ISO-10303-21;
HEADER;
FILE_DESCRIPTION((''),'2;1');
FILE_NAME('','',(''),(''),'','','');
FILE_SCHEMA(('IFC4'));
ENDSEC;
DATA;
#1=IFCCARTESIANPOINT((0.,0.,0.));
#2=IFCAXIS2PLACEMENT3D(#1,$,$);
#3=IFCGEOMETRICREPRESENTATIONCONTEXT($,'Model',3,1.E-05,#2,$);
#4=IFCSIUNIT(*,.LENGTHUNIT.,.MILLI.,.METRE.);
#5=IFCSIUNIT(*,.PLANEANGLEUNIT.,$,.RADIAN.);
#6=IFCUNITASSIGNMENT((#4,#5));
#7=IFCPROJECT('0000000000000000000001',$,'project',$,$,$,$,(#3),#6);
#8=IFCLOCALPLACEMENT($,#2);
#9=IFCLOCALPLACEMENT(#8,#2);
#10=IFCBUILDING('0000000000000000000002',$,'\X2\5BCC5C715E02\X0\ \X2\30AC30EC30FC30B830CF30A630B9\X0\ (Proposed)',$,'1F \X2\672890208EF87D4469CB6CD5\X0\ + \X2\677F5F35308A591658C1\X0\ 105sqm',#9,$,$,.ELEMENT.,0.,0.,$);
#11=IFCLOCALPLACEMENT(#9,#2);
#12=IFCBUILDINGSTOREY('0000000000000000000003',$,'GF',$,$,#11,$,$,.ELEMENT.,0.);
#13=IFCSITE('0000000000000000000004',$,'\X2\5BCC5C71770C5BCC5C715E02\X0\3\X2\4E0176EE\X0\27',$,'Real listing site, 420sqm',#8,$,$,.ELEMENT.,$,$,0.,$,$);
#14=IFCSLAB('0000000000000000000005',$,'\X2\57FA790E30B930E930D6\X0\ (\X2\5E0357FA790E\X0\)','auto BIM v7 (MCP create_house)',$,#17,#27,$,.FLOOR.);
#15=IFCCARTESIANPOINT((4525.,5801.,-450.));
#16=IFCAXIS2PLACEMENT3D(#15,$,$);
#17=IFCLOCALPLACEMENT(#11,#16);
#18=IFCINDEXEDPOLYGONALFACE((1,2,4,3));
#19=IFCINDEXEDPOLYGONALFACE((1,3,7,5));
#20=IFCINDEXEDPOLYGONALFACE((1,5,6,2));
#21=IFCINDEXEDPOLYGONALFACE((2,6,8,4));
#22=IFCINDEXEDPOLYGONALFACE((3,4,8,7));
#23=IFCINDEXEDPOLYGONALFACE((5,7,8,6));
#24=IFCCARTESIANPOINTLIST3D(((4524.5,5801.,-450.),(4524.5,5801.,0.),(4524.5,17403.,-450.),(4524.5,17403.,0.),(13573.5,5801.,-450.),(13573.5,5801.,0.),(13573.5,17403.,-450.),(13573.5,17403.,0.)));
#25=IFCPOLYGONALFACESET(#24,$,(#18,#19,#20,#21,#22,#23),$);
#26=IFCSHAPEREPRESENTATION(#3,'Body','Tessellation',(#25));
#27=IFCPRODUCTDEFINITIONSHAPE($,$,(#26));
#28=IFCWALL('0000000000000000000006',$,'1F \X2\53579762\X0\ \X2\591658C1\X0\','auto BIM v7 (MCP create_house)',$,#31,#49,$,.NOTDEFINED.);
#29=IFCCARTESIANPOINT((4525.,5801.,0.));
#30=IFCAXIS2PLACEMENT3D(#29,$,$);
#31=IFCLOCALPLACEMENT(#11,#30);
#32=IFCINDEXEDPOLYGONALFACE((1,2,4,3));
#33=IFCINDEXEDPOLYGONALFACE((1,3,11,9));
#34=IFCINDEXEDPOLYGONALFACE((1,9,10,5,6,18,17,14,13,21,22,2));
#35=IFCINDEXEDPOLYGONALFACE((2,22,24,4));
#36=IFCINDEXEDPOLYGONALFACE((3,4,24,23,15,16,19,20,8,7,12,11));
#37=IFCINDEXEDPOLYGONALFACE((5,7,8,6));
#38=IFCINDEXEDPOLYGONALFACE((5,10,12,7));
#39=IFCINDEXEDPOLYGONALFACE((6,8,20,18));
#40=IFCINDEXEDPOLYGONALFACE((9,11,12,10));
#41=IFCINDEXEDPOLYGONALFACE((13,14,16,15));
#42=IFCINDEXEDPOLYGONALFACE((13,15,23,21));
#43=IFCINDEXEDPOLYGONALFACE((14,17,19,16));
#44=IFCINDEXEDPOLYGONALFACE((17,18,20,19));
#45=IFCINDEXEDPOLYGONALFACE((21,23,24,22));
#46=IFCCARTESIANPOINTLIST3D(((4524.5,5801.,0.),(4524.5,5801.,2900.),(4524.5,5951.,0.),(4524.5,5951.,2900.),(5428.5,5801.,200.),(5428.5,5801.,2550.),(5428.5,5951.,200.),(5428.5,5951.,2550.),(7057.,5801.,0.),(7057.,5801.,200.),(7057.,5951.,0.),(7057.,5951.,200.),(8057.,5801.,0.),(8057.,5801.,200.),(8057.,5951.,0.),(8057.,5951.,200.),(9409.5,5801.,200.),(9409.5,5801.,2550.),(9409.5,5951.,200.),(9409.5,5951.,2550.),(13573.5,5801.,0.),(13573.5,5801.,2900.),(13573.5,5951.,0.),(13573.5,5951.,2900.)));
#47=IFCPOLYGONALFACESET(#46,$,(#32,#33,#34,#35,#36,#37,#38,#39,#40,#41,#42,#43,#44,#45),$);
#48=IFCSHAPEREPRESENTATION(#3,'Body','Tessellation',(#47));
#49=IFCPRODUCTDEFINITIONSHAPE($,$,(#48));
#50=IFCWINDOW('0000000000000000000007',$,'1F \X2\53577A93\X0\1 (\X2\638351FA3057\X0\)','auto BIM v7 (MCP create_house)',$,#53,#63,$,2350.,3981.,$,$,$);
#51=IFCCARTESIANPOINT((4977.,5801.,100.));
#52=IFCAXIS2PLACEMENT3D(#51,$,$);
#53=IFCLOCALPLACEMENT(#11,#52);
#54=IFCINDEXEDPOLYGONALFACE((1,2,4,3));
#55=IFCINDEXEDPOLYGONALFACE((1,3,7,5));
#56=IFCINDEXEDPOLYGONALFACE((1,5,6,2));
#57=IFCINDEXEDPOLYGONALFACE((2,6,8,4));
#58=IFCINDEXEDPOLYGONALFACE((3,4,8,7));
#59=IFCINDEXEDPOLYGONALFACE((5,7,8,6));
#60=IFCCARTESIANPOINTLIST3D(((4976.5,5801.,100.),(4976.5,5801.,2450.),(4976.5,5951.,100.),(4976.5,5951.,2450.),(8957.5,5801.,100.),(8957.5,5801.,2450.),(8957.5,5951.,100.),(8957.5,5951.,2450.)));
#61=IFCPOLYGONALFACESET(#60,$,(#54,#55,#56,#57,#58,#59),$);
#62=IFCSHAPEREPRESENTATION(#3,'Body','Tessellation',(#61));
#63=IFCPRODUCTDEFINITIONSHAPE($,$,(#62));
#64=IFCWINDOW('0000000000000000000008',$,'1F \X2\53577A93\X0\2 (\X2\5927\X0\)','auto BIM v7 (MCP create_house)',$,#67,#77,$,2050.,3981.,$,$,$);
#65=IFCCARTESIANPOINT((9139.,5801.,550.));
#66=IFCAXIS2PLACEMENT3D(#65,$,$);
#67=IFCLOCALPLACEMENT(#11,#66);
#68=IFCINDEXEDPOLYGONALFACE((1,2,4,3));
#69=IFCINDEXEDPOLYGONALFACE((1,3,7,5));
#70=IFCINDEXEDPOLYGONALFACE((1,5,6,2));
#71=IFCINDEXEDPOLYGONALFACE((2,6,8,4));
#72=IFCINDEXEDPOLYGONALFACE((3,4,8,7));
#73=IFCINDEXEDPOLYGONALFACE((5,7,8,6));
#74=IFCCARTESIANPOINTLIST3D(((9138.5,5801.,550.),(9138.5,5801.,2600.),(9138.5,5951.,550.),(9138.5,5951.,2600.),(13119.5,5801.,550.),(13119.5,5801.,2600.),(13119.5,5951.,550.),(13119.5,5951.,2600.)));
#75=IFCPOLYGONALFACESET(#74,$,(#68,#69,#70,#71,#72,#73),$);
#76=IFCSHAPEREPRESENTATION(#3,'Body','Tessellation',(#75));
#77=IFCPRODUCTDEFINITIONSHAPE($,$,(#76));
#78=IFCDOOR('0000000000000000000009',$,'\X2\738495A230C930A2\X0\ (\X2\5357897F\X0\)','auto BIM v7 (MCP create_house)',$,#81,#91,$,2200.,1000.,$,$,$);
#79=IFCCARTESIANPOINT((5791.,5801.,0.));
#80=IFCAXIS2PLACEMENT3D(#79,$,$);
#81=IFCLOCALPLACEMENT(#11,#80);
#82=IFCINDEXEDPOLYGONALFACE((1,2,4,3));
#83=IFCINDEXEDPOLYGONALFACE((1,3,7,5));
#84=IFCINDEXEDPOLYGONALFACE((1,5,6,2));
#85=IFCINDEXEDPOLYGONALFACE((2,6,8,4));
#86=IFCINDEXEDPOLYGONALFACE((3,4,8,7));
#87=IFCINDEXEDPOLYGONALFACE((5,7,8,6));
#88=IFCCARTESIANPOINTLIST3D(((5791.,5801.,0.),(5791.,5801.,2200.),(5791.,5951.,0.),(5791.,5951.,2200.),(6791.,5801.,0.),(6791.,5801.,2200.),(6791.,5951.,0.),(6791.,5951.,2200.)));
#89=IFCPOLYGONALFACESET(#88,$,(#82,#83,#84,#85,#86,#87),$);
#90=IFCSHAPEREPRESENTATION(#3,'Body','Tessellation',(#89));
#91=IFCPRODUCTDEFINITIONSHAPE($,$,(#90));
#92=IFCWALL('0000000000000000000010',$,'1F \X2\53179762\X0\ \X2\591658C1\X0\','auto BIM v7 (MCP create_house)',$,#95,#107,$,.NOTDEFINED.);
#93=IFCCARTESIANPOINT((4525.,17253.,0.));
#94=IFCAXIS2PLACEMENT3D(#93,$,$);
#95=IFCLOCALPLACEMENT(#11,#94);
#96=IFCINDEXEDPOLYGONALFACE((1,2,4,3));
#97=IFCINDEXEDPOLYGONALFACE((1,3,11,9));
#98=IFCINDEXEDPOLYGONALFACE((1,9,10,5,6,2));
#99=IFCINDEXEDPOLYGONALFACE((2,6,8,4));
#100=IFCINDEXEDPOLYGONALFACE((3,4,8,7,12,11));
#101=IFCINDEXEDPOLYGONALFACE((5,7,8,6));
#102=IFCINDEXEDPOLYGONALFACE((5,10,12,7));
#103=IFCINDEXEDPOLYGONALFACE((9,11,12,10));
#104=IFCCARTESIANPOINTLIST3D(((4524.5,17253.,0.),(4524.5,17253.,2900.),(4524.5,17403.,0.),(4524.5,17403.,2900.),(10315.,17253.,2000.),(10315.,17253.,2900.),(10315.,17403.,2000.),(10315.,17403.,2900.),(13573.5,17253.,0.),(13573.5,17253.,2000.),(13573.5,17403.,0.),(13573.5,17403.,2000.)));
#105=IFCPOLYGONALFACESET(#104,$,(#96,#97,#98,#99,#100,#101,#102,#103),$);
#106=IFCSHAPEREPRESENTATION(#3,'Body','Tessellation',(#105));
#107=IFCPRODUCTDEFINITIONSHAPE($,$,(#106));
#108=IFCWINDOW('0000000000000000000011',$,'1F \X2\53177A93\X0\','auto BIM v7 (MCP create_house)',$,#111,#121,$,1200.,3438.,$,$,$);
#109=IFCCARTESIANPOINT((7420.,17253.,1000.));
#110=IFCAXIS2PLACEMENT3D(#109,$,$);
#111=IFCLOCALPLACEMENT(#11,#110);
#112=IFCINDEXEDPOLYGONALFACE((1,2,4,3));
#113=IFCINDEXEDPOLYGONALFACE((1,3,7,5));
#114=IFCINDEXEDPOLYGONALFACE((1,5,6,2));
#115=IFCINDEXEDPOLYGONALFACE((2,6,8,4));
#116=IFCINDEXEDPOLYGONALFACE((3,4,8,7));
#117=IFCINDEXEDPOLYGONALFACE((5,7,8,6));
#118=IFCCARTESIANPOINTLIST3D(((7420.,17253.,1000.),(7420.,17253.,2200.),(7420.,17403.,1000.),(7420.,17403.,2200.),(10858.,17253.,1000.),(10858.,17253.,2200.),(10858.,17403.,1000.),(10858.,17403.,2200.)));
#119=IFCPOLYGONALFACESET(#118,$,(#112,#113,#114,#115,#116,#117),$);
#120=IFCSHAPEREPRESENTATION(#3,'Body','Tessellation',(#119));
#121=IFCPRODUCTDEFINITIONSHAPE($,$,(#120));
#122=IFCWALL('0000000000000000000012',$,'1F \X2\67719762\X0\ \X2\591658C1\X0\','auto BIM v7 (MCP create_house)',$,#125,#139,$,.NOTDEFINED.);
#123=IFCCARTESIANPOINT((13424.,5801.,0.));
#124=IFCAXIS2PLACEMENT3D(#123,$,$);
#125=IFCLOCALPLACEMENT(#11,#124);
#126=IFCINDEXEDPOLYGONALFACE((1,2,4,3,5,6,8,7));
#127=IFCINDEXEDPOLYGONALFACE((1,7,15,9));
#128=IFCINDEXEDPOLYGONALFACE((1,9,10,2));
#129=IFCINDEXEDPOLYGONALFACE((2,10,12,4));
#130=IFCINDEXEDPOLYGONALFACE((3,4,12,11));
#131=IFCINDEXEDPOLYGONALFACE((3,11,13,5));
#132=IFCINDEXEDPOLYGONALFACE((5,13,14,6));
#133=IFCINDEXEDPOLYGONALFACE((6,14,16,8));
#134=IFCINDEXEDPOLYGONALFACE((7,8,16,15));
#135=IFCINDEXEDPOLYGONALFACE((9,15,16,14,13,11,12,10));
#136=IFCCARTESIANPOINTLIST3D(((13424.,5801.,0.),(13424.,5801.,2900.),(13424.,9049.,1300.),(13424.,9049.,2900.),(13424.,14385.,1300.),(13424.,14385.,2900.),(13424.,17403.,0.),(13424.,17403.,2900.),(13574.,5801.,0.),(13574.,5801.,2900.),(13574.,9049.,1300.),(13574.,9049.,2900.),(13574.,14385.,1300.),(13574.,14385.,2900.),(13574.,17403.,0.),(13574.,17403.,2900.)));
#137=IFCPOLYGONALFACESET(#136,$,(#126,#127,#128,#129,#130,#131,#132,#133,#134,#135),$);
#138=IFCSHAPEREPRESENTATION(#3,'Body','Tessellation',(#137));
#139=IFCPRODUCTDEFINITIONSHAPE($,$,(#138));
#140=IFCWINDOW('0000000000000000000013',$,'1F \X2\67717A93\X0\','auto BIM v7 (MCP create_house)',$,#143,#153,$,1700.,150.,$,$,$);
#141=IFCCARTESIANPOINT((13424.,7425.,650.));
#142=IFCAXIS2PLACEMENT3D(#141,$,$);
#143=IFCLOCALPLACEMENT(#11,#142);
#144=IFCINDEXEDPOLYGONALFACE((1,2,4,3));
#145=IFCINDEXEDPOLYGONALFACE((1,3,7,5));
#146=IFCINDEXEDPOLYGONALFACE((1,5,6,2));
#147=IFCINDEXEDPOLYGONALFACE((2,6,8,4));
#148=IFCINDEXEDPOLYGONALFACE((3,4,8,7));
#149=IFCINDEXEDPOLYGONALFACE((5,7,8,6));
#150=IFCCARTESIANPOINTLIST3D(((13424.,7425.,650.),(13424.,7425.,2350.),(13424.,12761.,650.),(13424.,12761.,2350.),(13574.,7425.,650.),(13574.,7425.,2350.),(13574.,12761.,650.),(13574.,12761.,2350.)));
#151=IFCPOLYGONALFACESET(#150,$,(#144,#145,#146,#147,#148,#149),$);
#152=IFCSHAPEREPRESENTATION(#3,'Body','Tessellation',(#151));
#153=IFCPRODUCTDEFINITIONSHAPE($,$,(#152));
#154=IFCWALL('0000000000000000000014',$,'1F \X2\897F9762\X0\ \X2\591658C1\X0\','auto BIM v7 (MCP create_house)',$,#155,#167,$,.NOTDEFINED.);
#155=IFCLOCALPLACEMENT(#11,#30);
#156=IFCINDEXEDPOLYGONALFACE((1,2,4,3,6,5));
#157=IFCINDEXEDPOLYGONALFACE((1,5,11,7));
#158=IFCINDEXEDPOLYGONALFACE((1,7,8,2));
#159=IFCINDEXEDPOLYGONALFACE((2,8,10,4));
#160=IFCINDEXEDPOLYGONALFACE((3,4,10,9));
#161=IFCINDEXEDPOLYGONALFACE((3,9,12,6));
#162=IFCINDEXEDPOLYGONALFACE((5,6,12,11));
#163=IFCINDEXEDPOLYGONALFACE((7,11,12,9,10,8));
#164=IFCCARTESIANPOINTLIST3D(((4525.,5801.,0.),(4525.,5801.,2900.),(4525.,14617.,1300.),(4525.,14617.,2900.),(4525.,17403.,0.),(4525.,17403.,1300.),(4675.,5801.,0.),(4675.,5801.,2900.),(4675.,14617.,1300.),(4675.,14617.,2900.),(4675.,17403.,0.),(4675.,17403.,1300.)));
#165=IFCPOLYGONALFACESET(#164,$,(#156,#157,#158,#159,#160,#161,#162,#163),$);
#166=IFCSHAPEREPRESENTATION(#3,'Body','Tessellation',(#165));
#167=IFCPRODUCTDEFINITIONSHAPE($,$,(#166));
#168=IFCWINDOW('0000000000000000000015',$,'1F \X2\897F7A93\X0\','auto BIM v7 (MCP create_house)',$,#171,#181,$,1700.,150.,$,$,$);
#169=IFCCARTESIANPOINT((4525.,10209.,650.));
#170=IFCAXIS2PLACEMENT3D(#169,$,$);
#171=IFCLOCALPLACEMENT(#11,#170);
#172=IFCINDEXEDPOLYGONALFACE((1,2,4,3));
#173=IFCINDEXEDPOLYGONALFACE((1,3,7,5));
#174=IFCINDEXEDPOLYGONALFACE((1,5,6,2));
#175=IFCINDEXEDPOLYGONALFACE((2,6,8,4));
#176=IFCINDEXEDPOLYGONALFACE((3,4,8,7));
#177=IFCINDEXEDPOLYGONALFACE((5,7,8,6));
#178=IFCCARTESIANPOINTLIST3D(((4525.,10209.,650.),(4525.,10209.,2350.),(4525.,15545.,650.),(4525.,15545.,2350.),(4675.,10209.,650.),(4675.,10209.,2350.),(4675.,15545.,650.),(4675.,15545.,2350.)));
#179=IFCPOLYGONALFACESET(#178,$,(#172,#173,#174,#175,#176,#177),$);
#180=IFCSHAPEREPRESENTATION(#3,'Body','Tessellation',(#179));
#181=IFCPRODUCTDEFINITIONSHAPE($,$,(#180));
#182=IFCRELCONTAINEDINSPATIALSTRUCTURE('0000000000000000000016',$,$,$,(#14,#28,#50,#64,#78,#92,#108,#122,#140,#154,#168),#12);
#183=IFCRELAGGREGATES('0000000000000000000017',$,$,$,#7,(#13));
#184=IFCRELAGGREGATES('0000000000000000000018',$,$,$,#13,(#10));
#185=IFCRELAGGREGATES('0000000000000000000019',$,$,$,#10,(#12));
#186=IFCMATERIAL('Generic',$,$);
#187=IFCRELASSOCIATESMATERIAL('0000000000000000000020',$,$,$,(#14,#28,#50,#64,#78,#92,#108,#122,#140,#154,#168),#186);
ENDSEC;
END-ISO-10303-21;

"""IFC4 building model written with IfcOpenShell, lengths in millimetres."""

from ifc_helpers import new_model, si_unit, frame, frame_2d, origin, place, context, project, spatial, rectangle, extrude, material, element, fill, save


model = new_model("IFC4")

# Units and contexts
model_context = context("Model", 3, precision=1e-05, world=origin())
ifc_project = project(units=[si_unit("LENGTHUNIT", "METRE", prefix="MILLI"), si_unit("PLANEANGLEUNIT", "RADIAN")], contexts=[model_context])

# Site, building, storey
site_placement = place(None, origin())
site = spatial("IfcSite", under=ifc_project, at=site_placement, Name="富山県富山市3丁目27", ObjectType="Real listing site, 420sqm", CompositionType="ELEMENT", RefElevation=0.0)
building_placement = place(site_placement, origin())
building = spatial("IfcBuilding", under=site, at=building_placement, Name="富山市 ガレージハウス (Proposed)", ObjectType="1F 木造軸組構法 + 板張り外壁 105sqm", CompositionType="ELEMENT", ElevationOfRefHeight=0.0, ElevationOfTerrain=0.0)
storey_placement = place(building_placement, origin())
storey = spatial("IfcBuildingStorey", under=building, at=storey_placement, Name="GF", CompositionType="ELEMENT", Elevation=0.0)

# Slab
ifc_material = material(Name="Generic")
slab_1_placement = place(storey_placement, frame((4525.0, 5801.0, -450.0)))
element("IfcSlab", 1, at=slab_1_placement, inside=storey, material=ifc_material, Name="基礎スラブ (布基礎)", Description="auto BIM v7 (MCP create_house)", PredefinedType="FLOOR", context=model_context, shape_type="SweptSolid", body=[
    extrude(rectangle(XDim=9049.0, YDim=11602.0, at=frame_2d((4524.0, 5801.0))), frame((4525.0, 5801.0, -450.0)), (0.0, 0.0, 1.0), 450.0),
])

# Wall, openings, windows, door
wall_1_placement = place(storey_placement, frame((4525.0, 5801.0, 0.0)))
wall_1 = element("IfcWall", 2, at=wall_1_placement, inside=storey, material=ifc_material, Name="1F 南面 外壁", Description="auto BIM v7 (MCP create_house)", PredefinedType="NOTDEFINED", context=model_context, shape_type="SweptSolid", body=[
    extrude(rectangle(XDim=9049.0, YDim=150.0, at=frame_2d((4524.0, 75.0))), frame((4525.0, 5801.0, 0.0)), (0.0, 0.0, 1.0), 2900.0),
])
opening_1_placement = place(storey_placement, frame((4977.0, 5801.0, 100.0)))
opening_1 = element("IfcOpeningElement", 3, at=opening_1_placement, cuts=wall_1, PredefinedType="NOTDEFINED", context=model_context, shape_type="SweptSolid", body=[
    extrude(rectangle(XDim=3981.0, YDim=150.0, at=frame_2d((1990.0, 75.0))), frame((4977.0, 5801.0, 100.0)), (0.0, 0.0, 1.0), 2350.0),
])
opening_2_placement = place(storey_placement, frame((9139.0, 5801.0, 550.0)))
opening_2 = element("IfcOpeningElement", 4, at=opening_2_placement, cuts=wall_1, PredefinedType="NOTDEFINED", context=model_context, shape_type="SweptSolid", body=[
    extrude(rectangle(XDim=3981.0, YDim=150.0, at=frame_2d((1990.0, 75.0))), frame((9139.0, 5801.0, 550.0)), (0.0, 0.0, 1.0), 2050.0),
])
opening_3_placement = place(storey_placement, frame((5791.0, 5801.0, 0.0)))
opening_3 = element("IfcOpeningElement", 5, at=opening_3_placement, cuts=wall_1, PredefinedType="NOTDEFINED", context=model_context, shape_type="SweptSolid", body=[
    extrude(rectangle(XDim=1000.0, YDim=150.0, at=frame_2d((500.0, 75.0))), frame((5791.0, 5801.0, 0.0)), (0.0, 0.0, 1.0), 2200.0),
])
window_1_placement = place(storey_placement, frame((4977.0, 5801.0, 100.0)))
window_1 = element("IfcWindow", 6, at=window_1_placement, inside=storey, material=ifc_material, Name="1F 南窓1 (掃出し)", Description="auto BIM v7 (MCP create_house)", OverallHeight=2350.0, OverallWidth=3981.0, context=model_context, shape_type="SweptSolid", body=[
    extrude(rectangle(XDim=3981.0, YDim=150.0, at=frame_2d((1990.0, 75.0))), frame((4977.0, 5801.0, 100.0)), (0.0, 0.0, 1.0), 2350.0),
])
fill(opening_1, window_1)
window_2_placement = place(storey_placement, frame((9139.0, 5801.0, 550.0)))
window_2 = element("IfcWindow", 7, at=window_2_placement, inside=storey, material=ifc_material, Name="1F 南窓2 (大)", Description="auto BIM v7 (MCP create_house)", OverallHeight=2050.0, OverallWidth=3981.0, context=model_context, shape_type="SweptSolid", body=[
    extrude(rectangle(XDim=3981.0, YDim=150.0, at=frame_2d((1990.0, 75.0))), frame((9139.0, 5801.0, 550.0)), (0.0, 0.0, 1.0), 2050.0),
])
fill(opening_2, window_2)
door_placement = place(storey_placement, frame((5791.0, 5801.0, 0.0)))
door = element("IfcDoor", 8, at=door_placement, inside=storey, material=ifc_material, Name="玄関ドア (南西)", Description="auto BIM v7 (MCP create_house)", OverallHeight=2200.0, OverallWidth=1000.0, context=model_context, shape_type="SweptSolid", body=[
    extrude(rectangle(XDim=1000.0, YDim=150.0, at=frame_2d((500.0, 75.0))), frame((5791.0, 5801.0, 0.0)), (0.0, 0.0, 1.0), 2200.0),
])
fill(opening_3, door)

# Walls, openings, windows
wall_2_placement = place(storey_placement, frame((4525.0, 17253.0, 0.0)))
wall_2 = element("IfcWall", 9, at=wall_2_placement, inside=storey, material=ifc_material, Name="1F 北面 外壁", Description="auto BIM v7 (MCP create_house)", PredefinedType="NOTDEFINED", context=model_context, shape_type="SweptSolid", body=[
    extrude(rectangle(XDim=9049.0, YDim=150.0, at=frame_2d((4524.0, 75.0))), frame((4525.0, 17253.0, 0.0)), (0.0, 0.0, 1.0), 2900.0),
])
opening_4_placement = place(storey_placement, frame((7420.0, 17253.0, 1000.0)))
opening_4 = element("IfcOpeningElement", 10, at=opening_4_placement, cuts=wall_2, PredefinedType="NOTDEFINED", context=model_context, shape_type="SweptSolid", body=[
    extrude(rectangle(XDim=3438.0, YDim=150.0, at=frame_2d((1719.0, 75.0))), frame((7420.0, 17253.0, 1000.0)), (0.0, 0.0, 1.0), 1200.0),
])
window_3_placement = place(storey_placement, frame((7420.0, 17253.0, 1000.0)))
window_3 = element("IfcWindow", 11, at=window_3_placement, inside=storey, material=ifc_material, Name="1F 北窓", Description="auto BIM v7 (MCP create_house)", OverallHeight=1200.0, OverallWidth=3438.0, context=model_context, shape_type="SweptSolid", body=[
    extrude(rectangle(XDim=3438.0, YDim=150.0, at=frame_2d((1719.0, 75.0))), frame((7420.0, 17253.0, 1000.0)), (0.0, 0.0, 1.0), 1200.0),
])
fill(opening_4, window_3)
wall_3_placement = place(storey_placement, frame((13424.0, 5801.0, 0.0)))
wall_3 = element("IfcWall", 12, at=wall_3_placement, inside=storey, material=ifc_material, Name="1F 東面 外壁", Description="auto BIM v7 (MCP create_house)", PredefinedType="NOTDEFINED", context=model_context, shape_type="SweptSolid", body=[
    extrude(rectangle(XDim=150.0, YDim=11602.0, at=frame_2d((75.0, 5801.0))), frame((13424.0, 5801.0, 0.0)), (0.0, 0.0, 1.0), 2900.0),
])
opening_5_placement = place(storey_placement, frame((13424.0, 7425.0, 650.0)))
opening_5 = element("IfcOpeningElement", 13, at=opening_5_placement, cuts=wall_3, PredefinedType="NOTDEFINED", context=model_context, shape_type="SweptSolid", body=[
    extrude(rectangle(XDim=150.0, YDim=5336.0, at=frame_2d((75.0, 2668.0))), frame((13424.0, 7425.0, 650.0)), (0.0, 0.0, 1.0), 1700.0),
])
window_4_placement = place(storey_placement, frame((13424.0, 7425.0, 650.0)))
window_4 = element("IfcWindow", 14, at=window_4_placement, inside=storey, material=ifc_material, Name="1F 東窓", Description="auto BIM v7 (MCP create_house)", OverallHeight=1700.0, OverallWidth=150.0, context=model_context, shape_type="SweptSolid", body=[
    extrude(rectangle(XDim=150.0, YDim=5336.0, at=frame_2d((75.0, 2668.0))), frame((13424.0, 7425.0, 650.0)), (0.0, 0.0, 1.0), 1700.0),
])
fill(opening_5, window_4)
wall_4_placement = place(storey_placement, frame((4525.0, 5801.0, 0.0)))
wall_4 = element("IfcWall", 15, at=wall_4_placement, inside=storey, material=ifc_material, Name="1F 西面 外壁", Description="auto BIM v7 (MCP create_house)", PredefinedType="NOTDEFINED", context=model_context, shape_type="SweptSolid", body=[
    extrude(rectangle(XDim=150.0, YDim=11602.0, at=frame_2d((75.0, 5801.0))), frame((4525.0, 5801.0, 0.0)), (0.0, 0.0, 1.0), 2900.0),
])
opening_6_placement = place(storey_placement, frame((4525.0, 10209.0, 650.0)))
opening_6 = element("IfcOpeningElement", 16, at=opening_6_placement, cuts=wall_4, PredefinedType="NOTDEFINED", context=model_context, shape_type="SweptSolid", body=[
    extrude(rectangle(XDim=150.0, YDim=5336.0, at=frame_2d((75.0, 2668.0))), frame((4525.0, 10209.0, 650.0)), (0.0, 0.0, 1.0), 1700.0),
])
window_5_placement = place(storey_placement, frame((4525.0, 10209.0, 650.0)))
window_5 = element("IfcWindow", 17, at=window_5_placement, inside=storey, material=ifc_material, Name="1F 西窓", Description="auto BIM v7 (MCP create_house)", OverallHeight=1700.0, OverallWidth=150.0, context=model_context, shape_type="SweptSolid", body=[
    extrude(rectangle(XDim=150.0, YDim=5336.0, at=frame_2d((75.0, 2668.0))), frame((4525.0, 10209.0, 650.0)), (0.0, 0.0, 1.0), 1700.0),
])
fill(opening_6, window_5)

save(model, "model.ifc")
